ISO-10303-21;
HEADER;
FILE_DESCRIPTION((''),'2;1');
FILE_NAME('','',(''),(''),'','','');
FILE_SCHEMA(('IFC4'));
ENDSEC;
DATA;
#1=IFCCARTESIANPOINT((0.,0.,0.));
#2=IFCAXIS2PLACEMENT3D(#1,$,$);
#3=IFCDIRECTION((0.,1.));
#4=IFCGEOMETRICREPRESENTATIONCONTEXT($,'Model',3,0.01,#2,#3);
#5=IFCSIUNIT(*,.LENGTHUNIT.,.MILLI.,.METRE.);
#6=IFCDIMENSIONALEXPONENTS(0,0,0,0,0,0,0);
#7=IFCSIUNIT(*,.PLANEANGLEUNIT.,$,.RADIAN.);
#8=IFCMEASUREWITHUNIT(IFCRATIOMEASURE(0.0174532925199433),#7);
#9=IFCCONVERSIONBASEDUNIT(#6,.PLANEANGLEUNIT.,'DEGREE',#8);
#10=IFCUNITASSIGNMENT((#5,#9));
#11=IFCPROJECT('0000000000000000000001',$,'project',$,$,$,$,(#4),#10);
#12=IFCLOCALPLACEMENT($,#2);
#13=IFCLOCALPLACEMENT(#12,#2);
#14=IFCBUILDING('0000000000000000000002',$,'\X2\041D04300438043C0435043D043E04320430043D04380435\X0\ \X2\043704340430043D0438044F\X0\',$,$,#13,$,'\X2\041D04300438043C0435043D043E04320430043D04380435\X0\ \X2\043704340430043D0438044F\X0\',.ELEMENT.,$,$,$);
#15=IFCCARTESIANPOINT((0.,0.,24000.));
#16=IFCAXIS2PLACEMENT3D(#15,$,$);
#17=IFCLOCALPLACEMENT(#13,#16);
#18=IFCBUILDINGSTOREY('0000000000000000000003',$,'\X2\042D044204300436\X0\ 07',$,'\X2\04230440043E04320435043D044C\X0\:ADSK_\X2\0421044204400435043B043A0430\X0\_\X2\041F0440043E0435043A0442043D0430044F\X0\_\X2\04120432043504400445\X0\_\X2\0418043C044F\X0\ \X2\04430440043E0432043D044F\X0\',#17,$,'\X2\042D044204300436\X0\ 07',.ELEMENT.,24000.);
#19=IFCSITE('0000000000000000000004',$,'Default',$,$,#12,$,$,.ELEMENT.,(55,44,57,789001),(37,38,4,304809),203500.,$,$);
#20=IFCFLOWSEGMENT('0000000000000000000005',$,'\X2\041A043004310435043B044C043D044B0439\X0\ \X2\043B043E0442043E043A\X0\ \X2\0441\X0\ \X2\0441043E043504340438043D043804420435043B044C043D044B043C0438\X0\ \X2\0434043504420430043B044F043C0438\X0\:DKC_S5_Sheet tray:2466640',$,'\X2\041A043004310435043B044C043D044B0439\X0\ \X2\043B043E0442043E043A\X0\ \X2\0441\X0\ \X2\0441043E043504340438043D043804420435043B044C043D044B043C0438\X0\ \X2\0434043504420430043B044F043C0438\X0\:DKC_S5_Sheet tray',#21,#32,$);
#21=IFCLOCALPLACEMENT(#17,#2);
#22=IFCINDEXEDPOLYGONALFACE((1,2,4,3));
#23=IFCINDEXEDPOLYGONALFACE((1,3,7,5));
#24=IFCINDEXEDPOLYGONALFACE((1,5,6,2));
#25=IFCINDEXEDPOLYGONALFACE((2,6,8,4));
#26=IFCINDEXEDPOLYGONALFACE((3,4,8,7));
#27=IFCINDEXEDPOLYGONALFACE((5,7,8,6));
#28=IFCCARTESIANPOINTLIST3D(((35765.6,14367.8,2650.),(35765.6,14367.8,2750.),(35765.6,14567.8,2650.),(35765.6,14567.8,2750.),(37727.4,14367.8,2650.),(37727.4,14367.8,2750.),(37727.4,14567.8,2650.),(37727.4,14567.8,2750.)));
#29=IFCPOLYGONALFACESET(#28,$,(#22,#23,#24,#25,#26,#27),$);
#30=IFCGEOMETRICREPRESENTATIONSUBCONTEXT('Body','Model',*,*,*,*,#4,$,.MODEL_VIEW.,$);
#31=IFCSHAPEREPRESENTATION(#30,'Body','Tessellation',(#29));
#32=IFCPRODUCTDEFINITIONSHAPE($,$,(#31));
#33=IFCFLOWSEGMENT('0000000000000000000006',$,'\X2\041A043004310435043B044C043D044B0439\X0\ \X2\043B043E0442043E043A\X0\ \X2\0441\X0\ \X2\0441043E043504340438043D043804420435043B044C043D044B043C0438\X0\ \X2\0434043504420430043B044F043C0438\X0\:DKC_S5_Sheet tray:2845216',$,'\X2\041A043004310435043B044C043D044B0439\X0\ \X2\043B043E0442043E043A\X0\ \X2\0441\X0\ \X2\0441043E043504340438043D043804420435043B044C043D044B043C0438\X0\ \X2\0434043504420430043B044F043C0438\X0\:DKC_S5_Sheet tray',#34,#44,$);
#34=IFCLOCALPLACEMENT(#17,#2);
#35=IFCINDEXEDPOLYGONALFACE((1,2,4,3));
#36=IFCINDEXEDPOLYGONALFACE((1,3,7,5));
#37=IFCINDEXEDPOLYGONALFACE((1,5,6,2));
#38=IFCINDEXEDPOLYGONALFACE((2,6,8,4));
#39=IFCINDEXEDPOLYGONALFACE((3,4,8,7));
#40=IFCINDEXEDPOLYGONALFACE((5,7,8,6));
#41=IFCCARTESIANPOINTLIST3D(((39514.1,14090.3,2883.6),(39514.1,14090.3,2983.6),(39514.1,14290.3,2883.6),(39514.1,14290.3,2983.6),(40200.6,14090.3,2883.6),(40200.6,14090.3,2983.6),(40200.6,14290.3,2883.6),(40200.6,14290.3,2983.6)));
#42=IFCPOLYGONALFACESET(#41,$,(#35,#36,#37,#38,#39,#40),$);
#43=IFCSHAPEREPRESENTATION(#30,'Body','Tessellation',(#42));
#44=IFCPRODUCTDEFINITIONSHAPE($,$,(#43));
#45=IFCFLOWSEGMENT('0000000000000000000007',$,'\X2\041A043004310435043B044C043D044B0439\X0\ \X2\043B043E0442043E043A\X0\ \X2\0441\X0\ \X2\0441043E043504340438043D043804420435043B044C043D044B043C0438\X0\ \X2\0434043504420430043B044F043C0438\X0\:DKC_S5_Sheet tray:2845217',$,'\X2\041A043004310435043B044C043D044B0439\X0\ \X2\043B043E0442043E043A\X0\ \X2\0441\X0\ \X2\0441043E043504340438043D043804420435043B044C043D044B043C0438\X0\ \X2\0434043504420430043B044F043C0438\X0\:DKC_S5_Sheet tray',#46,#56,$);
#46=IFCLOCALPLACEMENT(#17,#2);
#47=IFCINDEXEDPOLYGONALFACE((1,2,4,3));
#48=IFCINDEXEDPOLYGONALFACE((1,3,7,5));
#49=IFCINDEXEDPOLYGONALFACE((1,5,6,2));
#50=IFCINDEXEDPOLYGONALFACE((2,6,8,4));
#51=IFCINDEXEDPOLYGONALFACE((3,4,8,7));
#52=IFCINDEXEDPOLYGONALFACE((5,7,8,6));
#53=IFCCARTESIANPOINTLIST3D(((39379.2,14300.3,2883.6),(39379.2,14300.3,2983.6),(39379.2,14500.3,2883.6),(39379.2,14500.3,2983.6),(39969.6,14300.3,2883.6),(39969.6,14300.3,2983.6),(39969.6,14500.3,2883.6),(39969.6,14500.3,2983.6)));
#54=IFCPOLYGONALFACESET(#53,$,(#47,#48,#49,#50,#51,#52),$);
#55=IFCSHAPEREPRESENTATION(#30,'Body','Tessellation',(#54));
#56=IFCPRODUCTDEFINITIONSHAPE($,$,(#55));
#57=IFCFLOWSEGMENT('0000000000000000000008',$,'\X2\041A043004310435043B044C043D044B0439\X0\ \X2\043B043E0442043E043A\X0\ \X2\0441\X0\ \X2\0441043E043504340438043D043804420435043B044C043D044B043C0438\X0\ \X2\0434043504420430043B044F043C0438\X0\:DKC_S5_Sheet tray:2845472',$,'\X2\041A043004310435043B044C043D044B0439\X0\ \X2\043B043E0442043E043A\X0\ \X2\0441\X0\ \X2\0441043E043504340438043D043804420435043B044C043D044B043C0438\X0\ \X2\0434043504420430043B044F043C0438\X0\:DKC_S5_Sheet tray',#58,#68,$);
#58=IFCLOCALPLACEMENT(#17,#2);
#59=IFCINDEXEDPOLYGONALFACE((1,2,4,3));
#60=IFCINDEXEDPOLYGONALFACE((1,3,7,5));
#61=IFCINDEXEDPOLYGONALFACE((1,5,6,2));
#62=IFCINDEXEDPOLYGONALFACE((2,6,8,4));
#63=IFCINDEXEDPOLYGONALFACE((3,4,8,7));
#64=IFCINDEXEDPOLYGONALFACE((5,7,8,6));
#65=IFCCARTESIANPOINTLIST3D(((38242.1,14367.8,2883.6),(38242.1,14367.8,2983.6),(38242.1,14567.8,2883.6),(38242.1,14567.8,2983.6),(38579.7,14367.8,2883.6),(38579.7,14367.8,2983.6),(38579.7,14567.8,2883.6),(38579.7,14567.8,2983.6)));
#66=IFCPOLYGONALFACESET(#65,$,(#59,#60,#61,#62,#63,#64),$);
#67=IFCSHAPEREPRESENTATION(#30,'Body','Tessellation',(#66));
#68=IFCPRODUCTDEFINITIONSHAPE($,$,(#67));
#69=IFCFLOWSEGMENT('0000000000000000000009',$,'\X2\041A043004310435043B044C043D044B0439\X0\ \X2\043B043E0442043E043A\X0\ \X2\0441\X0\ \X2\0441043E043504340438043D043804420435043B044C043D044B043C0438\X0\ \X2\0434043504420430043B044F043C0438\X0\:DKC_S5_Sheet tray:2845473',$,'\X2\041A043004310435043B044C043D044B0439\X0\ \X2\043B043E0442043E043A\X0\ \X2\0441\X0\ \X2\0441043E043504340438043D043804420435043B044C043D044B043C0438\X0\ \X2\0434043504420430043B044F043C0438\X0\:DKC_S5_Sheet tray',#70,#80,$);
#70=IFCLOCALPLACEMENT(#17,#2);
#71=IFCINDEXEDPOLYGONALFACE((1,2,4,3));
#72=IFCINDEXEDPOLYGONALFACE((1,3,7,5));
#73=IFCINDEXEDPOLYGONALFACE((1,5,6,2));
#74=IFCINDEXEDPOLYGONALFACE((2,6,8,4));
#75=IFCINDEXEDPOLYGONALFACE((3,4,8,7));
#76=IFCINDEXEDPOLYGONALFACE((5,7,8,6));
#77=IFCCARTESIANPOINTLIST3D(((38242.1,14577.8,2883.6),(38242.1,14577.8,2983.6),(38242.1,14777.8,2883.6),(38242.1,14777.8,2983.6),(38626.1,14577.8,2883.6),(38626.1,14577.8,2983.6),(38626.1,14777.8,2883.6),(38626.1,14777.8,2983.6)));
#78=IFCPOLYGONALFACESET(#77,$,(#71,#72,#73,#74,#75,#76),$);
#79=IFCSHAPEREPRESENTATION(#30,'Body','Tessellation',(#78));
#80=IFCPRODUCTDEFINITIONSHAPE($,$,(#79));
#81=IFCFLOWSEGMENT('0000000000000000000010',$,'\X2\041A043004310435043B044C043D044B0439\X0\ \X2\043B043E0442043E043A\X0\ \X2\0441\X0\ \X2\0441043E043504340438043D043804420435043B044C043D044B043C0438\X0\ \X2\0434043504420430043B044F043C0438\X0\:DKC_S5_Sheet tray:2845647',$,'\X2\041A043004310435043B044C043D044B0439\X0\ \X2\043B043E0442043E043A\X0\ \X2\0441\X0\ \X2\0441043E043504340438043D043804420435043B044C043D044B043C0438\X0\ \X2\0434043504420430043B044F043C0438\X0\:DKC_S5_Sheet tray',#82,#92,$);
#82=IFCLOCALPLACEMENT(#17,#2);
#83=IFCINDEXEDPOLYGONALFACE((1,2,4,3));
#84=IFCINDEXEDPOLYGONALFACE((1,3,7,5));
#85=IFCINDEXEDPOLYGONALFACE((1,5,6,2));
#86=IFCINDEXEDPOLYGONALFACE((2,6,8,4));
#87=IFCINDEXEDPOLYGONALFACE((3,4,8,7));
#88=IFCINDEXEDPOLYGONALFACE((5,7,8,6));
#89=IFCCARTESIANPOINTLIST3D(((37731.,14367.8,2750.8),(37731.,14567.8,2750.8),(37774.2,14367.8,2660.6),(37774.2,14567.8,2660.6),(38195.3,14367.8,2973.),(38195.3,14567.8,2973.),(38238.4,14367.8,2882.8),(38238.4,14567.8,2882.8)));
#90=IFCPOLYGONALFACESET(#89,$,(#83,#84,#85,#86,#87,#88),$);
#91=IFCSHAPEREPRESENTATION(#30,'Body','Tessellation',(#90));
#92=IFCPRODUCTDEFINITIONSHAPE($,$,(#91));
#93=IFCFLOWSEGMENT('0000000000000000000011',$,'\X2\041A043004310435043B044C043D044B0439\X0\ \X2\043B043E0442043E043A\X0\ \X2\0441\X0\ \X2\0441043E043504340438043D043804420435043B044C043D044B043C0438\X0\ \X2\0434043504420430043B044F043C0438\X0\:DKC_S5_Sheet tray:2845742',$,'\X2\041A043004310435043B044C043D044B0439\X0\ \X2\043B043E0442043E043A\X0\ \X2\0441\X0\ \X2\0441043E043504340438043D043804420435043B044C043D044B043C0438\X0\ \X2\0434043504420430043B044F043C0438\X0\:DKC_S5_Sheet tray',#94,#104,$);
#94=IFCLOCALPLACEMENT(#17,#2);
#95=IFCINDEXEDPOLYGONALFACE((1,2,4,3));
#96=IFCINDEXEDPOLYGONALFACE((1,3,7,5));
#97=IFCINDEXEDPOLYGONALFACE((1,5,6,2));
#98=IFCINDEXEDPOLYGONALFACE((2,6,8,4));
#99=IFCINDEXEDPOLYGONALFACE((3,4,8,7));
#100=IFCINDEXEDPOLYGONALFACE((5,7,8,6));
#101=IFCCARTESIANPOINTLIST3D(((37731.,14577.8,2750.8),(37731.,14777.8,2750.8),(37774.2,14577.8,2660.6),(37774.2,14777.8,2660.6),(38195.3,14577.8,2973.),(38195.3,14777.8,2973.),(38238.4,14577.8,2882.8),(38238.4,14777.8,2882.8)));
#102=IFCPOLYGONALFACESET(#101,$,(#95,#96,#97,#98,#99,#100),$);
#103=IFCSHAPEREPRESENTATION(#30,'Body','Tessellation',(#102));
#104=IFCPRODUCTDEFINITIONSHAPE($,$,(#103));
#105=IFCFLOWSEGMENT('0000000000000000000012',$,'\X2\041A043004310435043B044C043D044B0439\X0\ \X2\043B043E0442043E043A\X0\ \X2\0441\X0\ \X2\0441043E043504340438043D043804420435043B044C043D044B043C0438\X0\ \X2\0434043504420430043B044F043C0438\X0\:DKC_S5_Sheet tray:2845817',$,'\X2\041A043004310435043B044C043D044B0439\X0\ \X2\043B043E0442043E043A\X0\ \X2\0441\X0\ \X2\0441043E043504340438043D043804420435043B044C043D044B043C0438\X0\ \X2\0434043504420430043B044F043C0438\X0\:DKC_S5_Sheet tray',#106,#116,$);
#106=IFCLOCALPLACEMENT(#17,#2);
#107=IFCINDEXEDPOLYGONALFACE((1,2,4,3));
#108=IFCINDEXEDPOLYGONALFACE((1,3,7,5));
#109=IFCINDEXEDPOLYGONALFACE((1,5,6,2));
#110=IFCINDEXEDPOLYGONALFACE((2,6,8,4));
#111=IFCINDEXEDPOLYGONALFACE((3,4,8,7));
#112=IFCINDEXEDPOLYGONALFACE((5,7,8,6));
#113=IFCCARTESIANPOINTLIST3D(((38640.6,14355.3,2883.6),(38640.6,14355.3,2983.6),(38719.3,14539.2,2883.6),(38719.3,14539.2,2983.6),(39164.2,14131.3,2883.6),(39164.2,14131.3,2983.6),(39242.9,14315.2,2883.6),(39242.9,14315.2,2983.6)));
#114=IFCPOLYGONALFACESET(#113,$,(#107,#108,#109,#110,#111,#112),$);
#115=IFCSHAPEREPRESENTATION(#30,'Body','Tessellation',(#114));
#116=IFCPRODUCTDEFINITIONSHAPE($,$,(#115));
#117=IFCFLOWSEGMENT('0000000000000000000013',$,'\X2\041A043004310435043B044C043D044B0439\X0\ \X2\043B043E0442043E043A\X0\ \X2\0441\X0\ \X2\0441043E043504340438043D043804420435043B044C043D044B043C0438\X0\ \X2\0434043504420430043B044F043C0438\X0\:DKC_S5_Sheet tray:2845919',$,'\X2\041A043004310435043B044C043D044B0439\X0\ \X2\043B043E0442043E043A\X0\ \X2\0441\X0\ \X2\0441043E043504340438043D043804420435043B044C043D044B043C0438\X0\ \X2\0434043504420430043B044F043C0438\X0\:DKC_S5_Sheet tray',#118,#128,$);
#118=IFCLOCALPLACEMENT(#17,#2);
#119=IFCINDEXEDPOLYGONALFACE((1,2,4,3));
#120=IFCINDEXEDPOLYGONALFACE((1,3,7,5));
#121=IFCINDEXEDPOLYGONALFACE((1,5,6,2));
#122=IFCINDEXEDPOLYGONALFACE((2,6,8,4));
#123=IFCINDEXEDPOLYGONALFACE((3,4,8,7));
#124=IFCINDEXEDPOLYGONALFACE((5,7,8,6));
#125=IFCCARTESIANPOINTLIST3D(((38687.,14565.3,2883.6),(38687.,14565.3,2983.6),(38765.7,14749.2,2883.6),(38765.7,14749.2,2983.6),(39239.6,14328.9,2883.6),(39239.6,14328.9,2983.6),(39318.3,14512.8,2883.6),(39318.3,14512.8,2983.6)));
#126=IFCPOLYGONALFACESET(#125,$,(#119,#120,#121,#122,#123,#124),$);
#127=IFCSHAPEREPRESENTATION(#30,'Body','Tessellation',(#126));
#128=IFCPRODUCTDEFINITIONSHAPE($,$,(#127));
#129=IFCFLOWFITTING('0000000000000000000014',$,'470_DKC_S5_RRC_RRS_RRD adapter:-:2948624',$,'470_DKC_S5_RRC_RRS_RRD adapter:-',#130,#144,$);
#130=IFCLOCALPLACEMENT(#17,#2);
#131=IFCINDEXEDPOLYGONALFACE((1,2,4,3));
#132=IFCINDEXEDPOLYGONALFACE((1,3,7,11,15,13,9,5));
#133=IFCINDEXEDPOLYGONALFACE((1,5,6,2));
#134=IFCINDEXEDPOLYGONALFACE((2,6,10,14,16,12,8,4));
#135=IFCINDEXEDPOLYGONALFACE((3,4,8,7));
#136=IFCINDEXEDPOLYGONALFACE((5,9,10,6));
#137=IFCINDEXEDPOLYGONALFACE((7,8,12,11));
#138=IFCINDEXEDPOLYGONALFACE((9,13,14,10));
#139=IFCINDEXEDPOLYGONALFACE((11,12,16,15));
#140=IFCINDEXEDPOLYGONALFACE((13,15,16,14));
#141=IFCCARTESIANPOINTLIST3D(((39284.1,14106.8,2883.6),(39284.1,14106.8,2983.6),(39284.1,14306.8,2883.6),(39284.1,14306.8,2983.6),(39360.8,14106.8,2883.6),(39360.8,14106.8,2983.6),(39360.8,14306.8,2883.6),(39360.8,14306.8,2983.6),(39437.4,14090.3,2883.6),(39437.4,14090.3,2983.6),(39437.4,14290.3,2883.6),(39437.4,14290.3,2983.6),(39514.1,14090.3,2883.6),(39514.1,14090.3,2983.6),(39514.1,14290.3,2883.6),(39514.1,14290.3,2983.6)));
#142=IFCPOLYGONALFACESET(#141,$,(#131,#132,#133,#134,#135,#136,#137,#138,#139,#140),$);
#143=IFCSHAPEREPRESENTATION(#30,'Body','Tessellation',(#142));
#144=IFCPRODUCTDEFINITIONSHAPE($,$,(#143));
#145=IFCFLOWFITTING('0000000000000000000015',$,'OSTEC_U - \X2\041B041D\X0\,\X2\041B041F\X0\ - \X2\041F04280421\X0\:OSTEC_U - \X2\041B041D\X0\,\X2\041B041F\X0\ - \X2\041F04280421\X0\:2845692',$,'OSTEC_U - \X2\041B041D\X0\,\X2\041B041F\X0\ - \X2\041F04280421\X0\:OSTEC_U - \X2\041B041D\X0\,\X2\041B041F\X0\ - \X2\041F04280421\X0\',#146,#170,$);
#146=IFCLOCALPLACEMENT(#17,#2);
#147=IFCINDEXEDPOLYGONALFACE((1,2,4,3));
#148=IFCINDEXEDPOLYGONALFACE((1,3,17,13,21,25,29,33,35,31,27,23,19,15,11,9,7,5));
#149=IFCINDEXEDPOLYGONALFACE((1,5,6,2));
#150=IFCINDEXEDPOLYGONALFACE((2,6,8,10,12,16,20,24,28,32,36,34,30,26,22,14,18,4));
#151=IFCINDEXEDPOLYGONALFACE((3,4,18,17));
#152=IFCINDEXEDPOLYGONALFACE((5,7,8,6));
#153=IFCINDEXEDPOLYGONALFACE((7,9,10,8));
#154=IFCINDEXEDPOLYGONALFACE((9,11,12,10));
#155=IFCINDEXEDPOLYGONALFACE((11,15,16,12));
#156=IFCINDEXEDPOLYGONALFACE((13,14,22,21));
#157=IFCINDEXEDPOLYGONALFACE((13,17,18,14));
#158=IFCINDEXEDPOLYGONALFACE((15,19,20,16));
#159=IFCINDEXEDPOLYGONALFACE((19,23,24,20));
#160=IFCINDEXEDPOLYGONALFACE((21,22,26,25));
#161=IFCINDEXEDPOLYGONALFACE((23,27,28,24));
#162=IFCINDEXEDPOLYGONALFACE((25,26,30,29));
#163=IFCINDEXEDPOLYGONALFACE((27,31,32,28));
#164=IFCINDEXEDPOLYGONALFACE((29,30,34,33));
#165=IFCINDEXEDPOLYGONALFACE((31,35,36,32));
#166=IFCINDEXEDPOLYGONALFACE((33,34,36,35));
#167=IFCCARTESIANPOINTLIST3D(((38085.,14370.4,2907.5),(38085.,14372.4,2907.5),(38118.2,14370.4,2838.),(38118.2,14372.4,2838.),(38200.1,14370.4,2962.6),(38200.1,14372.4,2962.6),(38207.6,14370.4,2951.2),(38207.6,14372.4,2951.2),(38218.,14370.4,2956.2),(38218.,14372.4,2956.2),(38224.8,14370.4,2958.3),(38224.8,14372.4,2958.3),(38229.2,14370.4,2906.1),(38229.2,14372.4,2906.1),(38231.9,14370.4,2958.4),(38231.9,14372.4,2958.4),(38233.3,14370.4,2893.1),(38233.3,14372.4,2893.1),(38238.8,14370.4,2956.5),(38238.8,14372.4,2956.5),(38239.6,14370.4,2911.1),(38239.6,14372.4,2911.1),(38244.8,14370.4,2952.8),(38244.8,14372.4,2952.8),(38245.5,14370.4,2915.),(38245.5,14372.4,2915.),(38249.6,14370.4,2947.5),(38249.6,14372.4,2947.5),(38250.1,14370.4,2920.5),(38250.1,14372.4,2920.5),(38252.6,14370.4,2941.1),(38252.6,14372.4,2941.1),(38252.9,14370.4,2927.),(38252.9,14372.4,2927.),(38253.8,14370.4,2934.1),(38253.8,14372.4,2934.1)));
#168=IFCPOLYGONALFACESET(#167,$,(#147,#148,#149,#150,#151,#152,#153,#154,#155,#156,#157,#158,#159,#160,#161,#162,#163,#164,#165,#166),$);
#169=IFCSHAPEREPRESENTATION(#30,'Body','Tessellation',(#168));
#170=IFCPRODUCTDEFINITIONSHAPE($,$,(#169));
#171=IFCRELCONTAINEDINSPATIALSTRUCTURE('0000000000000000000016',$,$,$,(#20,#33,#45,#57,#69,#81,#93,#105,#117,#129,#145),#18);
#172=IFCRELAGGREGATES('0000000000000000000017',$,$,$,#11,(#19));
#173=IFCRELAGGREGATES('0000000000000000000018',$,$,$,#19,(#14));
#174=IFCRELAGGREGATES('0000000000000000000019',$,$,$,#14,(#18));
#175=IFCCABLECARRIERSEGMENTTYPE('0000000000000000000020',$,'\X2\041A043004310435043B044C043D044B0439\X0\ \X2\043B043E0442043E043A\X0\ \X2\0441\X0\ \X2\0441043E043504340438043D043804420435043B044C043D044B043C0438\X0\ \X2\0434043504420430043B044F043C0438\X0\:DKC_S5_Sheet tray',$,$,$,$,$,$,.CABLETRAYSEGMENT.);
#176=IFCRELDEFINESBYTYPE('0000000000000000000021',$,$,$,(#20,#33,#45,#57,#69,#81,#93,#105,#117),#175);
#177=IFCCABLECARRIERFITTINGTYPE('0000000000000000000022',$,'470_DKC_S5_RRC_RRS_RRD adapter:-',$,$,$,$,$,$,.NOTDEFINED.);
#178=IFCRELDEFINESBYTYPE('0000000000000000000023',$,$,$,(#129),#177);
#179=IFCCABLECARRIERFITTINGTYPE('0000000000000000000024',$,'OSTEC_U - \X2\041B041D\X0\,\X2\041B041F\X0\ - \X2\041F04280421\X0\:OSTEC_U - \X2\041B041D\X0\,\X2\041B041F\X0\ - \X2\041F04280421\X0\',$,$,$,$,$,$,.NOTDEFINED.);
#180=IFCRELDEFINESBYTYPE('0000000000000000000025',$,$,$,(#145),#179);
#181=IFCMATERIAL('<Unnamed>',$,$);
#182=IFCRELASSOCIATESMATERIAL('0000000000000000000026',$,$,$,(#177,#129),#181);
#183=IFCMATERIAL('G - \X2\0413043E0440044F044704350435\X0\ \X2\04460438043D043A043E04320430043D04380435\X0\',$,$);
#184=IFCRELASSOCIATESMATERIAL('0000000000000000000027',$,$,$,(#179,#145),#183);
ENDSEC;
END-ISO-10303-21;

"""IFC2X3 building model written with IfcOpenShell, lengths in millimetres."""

from ifc_helpers import new_model, entity, si_unit, converted_unit, direction, frame, frame_2d, origin, origin_2d_with_axis, place, context, subcontext, project, spatial, polyline, circle_curve, parameter, trimmed, segment, composite_curve, rectangle, outline, extrude, source, transform, mapped, material, type_object, type_shapes, element, save


model = new_model("IFC2X3")

# Units and contexts
model_context = context("Model", 3, precision=0.01, world=origin(), true_north=direction((0.0, 1.0)))
body_context = subcontext(model_context, "Body", "Model", "MODEL_VIEW")
ifc_project = project(units=[si_unit("LENGTHUNIT", "METRE", prefix="MILLI"), converted_unit("PLANEANGLEUNIT", "DEGREE", entity("IfcRatioMeasure", 0.0174532925199433), si_unit("PLANEANGLEUNIT", "RADIAN"), dimensions=[0, 0, 0, 0, 0, 0, 0])], contexts=[model_context])

# Site, building, storey
site_placement = place(None, origin())
site = spatial("IfcSite", under=ifc_project, at=site_placement, Name="Default", CompositionType="ELEMENT", RefLatitude=(55, 44, 57, 789001), RefLongitude=(37, 38, 4, 304809), RefElevation=203500.0)
building_placement = place(site_placement, origin())
building = spatial("IfcBuilding", under=site, at=building_placement, Name="Наименование здания", LongName="Наименование здания", CompositionType="ELEMENT")
storey_placement = place(building_placement, frame((0.0, 0.0, 24000.0)))
storey = spatial("IfcBuildingStorey", under=building, at=storey_placement, Name="Этаж 07", ObjectType="Уровень:ADSK_Стрелка_Проектная_Вверх_Имя уровня", LongName="Этаж 07", CompositionType="ELEMENT", Elevation=24000.0)

# Flow segments
cable_carrier_segment_type = type_object("IfcCableCarrierSegmentType", Name="Кабельный лоток с соединительными деталями:DKC_S5_Sheet tray", PredefinedType="CABLETRAYSEGMENT")
flow_segment_1_placement = place(storey_placement, frame((35765.6, 14367.8, 2650.0)))
element("IfcFlowSegment", 1, at=flow_segment_1_placement, inside=storey, type_object=cable_carrier_segment_type, Name="Кабельный лоток с соединительными деталями:DKC_S5_Sheet tray:2466640", ObjectType="Кабельный лоток с соединительными деталями:DKC_S5_Sheet tray", context=body_context, shape_type="SweptSolid", body=[
    extrude(rectangle(XDim=1961.7, YDim=200.0, at=origin_2d_with_axis()), frame((980.9, 100.0, 0.0)), (0.0, 0.0, 1.0), 100.0),
])
flow_segment_2_placement = place(storey_placement, frame((39514.1, 14090.3, 2883.6)))
element("IfcFlowSegment", 2, at=flow_segment_2_placement, inside=storey, type_object=cable_carrier_segment_type, Name="Кабельный лоток с соединительными деталями:DKC_S5_Sheet tray:2845216", ObjectType="Кабельный лоток с соединительными деталями:DKC_S5_Sheet tray", context=body_context, shape_type="SweptSolid", body=[
    extrude(rectangle(XDim=686.5, YDim=200.0, at=origin_2d_with_axis()), frame((343.2, 100.0, 0.0), z_axis=(0.0, 0.0, 1.0), x_axis=(-1.0, 0.0, 0.0)), (0.0, 0.0, 1.0), 100.0),
])
flow_segment_3_placement = place(storey_placement, frame((39379.2, 14300.3, 2883.6)))
element("IfcFlowSegment", 3, at=flow_segment_3_placement, inside=storey, type_object=cable_carrier_segment_type, Name="Кабельный лоток с соединительными деталями:DKC_S5_Sheet tray:2845217", ObjectType="Кабельный лоток с соединительными деталями:DKC_S5_Sheet tray", context=body_context, shape_type="SweptSolid", body=[
    extrude(rectangle(XDim=590.4, YDim=200.0, at=origin_2d_with_axis()), frame((295.2, 100.0, 0.0), z_axis=(0.0, 0.0, 1.0), x_axis=(-1.0, 0.0, 0.0)), (0.0, 0.0, 1.0), 100.0),
])
flow_segment_4_placement = place(storey_placement, frame((38242.1, 14367.8, 2883.6)))
element("IfcFlowSegment", 4, at=flow_segment_4_placement, inside=storey, type_object=cable_carrier_segment_type, Name="Кабельный лоток с соединительными деталями:DKC_S5_Sheet tray:2845472", ObjectType="Кабельный лоток с соединительными деталями:DKC_S5_Sheet tray", context=body_context, shape_type="SweptSolid", body=[
    extrude(rectangle(XDim=337.6, YDim=200.0, at=origin_2d_with_axis()), frame((168.8, 100.0, 0.0), z_axis=(0.0, 0.0, 1.0), x_axis=(-1.0, 0.0, 0.0)), (0.0, 0.0, 1.0), 100.0),
])
flow_segment_5_placement = place(storey_placement, frame((38242.1, 14577.8, 2883.6)))
element("IfcFlowSegment", 5, at=flow_segment_5_placement, inside=storey, type_object=cable_carrier_segment_type, Name="Кабельный лоток с соединительными деталями:DKC_S5_Sheet tray:2845473", ObjectType="Кабельный лоток с соединительными деталями:DKC_S5_Sheet tray", context=body_context, shape_type="SweptSolid", body=[
    extrude(rectangle(XDim=384.0, YDim=200.0, at=origin_2d_with_axis()), frame((192.0, 100.0, 0.0)), (0.0, 0.0, 1.0), 100.0),
])
flow_segment_6_placement = place(storey_placement, frame((37731.0, 14367.8, 2660.6)))
element("IfcFlowSegment", 6, at=flow_segment_6_placement, inside=storey, type_object=cable_carrier_segment_type, Name="Кабельный лоток с соединительными деталями:DKC_S5_Sheet tray:2845647", ObjectType="Кабельный лоток с соединительными деталями:DKC_S5_Sheet tray", context=body_context, shape_type="SweptSolid", body=[
    extrude(rectangle(XDim=100.0, YDim=200.0, at=origin_2d_with_axis()), frame((21.6, 100.0, 45.1), z_axis=(0.90203, 0.0, 0.431673), x_axis=(-0.431673, 0.0, 0.90203)), (0.0, 0.0, 1.0), 514.7),
])
flow_segment_7_placement = place(storey_placement, frame((37731.0, 14577.8, 2660.6)))
element("IfcFlowSegment", 7, at=flow_segment_7_placement, inside=storey, type_object=cable_carrier_segment_type, Name="Кабельный лоток с соединительными деталями:DKC_S5_Sheet tray:2845742", ObjectType="Кабельный лоток с соединительными деталями:DKC_S5_Sheet tray", context=body_context, shape_type="SweptSolid", body=[
    extrude(rectangle(XDim=100.0, YDim=200.0, at=origin_2d_with_axis()), frame((21.6, 100.0, 45.1), z_axis=(0.90203, 0.0, 0.431673), x_axis=(-0.431673, 0.0, 0.90203)), (0.0, 0.0, 1.0), 514.7),
])
flow_segment_8_placement = place(storey_placement, frame((38640.6, 14131.4, 2883.6)))
element("IfcFlowSegment", 8, at=flow_segment_8_placement, inside=storey, type_object=cable_carrier_segment_type, Name="Кабельный лоток с соединительными деталями:DKC_S5_Sheet tray:2845817", ObjectType="Кабельный лоток с соединительными деталями:DKC_S5_Sheet tray", context=body_context, shape_type="SweptSolid", body=[
    extrude(rectangle(XDim=569.5, YDim=200.0, at=origin_2d_with_axis()), frame((301.1, 203.9, 0.0), z_axis=(0.0, 0.0, 1.0), x_axis=(-0.9194, 0.393323, 0.0)), (0.0, 0.0, 1.0), 100.0),
])
flow_segment_9_placement = place(storey_placement, frame((38687.0, 14328.9, 2883.6)))
element("IfcFlowSegment", 9, at=flow_segment_9_placement, inside=storey, type_object=cable_carrier_segment_type, Name="Кабельный лоток с соединительными деталями:DKC_S5_Sheet tray:2845919", ObjectType="Кабельный лоток с соединительными деталями:DKC_S5_Sheet tray", context=body_context, shape_type="SweptSolid", body=[
    extrude(rectangle(XDim=601.1, YDim=200.0, at=origin_2d_with_axis()), frame((315.6, 210.2, 0.0), z_axis=(0.0, 0.0, 1.0), x_axis=(-0.9194, 0.393323, 0.0)), (0.0, 0.0, 1.0), 100.0),
])

# Flow fittings
ifc_material_1 = material(Name="<Unnamed>")
cable_carrier_fitting_type_1 = type_object("IfcCableCarrierFittingType", Name="470_DKC_S5_RRC_RRS_RRD adapter:-", PredefinedType="NOTDEFINED", material=ifc_material_1)
shared_shape_1 = source(origin(), body_context, "Body", "SweptSolid", [
    extrude(outline(polyline([(-115.0, 91.8), (-115.0, -108.2), (-38.3, -108.2), (38.3, -91.8), (115.0, -91.8), (115.0, 108.2), (38.3, 108.2), (-38.3, 91.8), (-115.0, 91.8)])), frame((115.0, -8.2, -50.0), z_axis=(0.0, 0.0, -1.0), x_axis=(1.0, 0.0, 0.0)), (0.0, 0.0, -1.0), 100.0),
])
type_shapes(cable_carrier_fitting_type_1, [shared_shape_1])
flow_fitting_1_placement = place(storey_placement, frame((39514.1, 14190.3, 2933.6), z_axis=(0.0, 0.0, 1.0), x_axis=(-1.0, 0.0, 0.0)))
element("IfcFlowFitting", 10, at=flow_fitting_1_placement, inside=storey, type_object=cable_carrier_fitting_type_1, material=ifc_material_1, Name="470_DKC_S5_RRC_RRS_RRD adapter:-:2948624", ObjectType="470_DKC_S5_RRC_RRS_RRD adapter:-", context=body_context, shape_type="MappedRepresentation", body=[
    mapped(shared_shape_1, transform((0.0, 0.0, 0.0), scale=1.0)),
])
ifc_material_2 = material(Name="G - Горячее цинкование")
cable_carrier_fitting_type_2 = type_object("IfcCableCarrierFittingType", Name="OSTEC_U - ЛН,ЛП - ПШС:OSTEC_U - ЛН,ЛП - ПШС", PredefinedType="NOTDEFINED", material=ifc_material_2)
shared_shape_2 = source(origin(), body_context, "Body", "SweptSolid", [
    extrude(outline(composite_curve([segment(trimmed(circle_curve(frame_2d((-41.5, 0.0), x_axis=(1.0, 0.0)), 25.0), [parameter(90.0)], [parameter(270.0)], True, "PARAMETER"), True, "CONTINUOUS"), segment(polyline([(-41.5, -25.0), (-30.0, -25.0)]), True, "CONTINUOUS"), segment(polyline([(-30.0, -25.0), (-28.1, -38.5)]), True, "CONTINUOUS"), segment(polyline([(-28.1, -38.5), (99.5, -38.5)]), True, "CONTINUOUS"), segment(polyline([(99.5, -38.5), (99.5, 38.5)]), True, "CONTINUOUS"), segment(polyline([(99.5, 38.5), (-28.1, 38.5)]), True, "CONTINUOUS"), segment(polyline([(-28.1, 38.5), (-30.0, 25.0)]), True, "CONTINUOUS"), segment(polyline([(-30.0, 25.0), (-41.5, 25.0)]), True, "CONTINUOUS")], self_intersect=False)), frame((41.5, 0.0, 0.0), z_axis=(0.0, 0.0, -1.0), x_axis=(1.0, 0.0, 0.0)), (0.0, 0.0, -1.0), 2.0),
])
type_shapes(cable_carrier_fitting_type_2, [shared_shape_2])
flow_fitting_2_placement = place(storey_placement, frame((38228.8, 14372.4, 2933.6), z_axis=(0.0, -1.0, 0.0), x_axis=(-0.90203, 0.0, -0.431673)))
element("IfcFlowFitting", 11, at=flow_fitting_2_placement, inside=storey, type_object=cable_carrier_fitting_type_2, material=ifc_material_2, Name="OSTEC_U - ЛН,ЛП - ПШС:OSTEC_U - ЛН,ЛП - ПШС:2845692", ObjectType="OSTEC_U - ЛН,ЛП - ПШС:OSTEC_U - ЛН,ЛП - ПШС", context=body_context, shape_type="MappedRepresentation", body=[
    mapped(shared_shape_2, transform((0.0, 0.0, 0.0), scale=1.0)),
])

save(model, "model.ifc")
